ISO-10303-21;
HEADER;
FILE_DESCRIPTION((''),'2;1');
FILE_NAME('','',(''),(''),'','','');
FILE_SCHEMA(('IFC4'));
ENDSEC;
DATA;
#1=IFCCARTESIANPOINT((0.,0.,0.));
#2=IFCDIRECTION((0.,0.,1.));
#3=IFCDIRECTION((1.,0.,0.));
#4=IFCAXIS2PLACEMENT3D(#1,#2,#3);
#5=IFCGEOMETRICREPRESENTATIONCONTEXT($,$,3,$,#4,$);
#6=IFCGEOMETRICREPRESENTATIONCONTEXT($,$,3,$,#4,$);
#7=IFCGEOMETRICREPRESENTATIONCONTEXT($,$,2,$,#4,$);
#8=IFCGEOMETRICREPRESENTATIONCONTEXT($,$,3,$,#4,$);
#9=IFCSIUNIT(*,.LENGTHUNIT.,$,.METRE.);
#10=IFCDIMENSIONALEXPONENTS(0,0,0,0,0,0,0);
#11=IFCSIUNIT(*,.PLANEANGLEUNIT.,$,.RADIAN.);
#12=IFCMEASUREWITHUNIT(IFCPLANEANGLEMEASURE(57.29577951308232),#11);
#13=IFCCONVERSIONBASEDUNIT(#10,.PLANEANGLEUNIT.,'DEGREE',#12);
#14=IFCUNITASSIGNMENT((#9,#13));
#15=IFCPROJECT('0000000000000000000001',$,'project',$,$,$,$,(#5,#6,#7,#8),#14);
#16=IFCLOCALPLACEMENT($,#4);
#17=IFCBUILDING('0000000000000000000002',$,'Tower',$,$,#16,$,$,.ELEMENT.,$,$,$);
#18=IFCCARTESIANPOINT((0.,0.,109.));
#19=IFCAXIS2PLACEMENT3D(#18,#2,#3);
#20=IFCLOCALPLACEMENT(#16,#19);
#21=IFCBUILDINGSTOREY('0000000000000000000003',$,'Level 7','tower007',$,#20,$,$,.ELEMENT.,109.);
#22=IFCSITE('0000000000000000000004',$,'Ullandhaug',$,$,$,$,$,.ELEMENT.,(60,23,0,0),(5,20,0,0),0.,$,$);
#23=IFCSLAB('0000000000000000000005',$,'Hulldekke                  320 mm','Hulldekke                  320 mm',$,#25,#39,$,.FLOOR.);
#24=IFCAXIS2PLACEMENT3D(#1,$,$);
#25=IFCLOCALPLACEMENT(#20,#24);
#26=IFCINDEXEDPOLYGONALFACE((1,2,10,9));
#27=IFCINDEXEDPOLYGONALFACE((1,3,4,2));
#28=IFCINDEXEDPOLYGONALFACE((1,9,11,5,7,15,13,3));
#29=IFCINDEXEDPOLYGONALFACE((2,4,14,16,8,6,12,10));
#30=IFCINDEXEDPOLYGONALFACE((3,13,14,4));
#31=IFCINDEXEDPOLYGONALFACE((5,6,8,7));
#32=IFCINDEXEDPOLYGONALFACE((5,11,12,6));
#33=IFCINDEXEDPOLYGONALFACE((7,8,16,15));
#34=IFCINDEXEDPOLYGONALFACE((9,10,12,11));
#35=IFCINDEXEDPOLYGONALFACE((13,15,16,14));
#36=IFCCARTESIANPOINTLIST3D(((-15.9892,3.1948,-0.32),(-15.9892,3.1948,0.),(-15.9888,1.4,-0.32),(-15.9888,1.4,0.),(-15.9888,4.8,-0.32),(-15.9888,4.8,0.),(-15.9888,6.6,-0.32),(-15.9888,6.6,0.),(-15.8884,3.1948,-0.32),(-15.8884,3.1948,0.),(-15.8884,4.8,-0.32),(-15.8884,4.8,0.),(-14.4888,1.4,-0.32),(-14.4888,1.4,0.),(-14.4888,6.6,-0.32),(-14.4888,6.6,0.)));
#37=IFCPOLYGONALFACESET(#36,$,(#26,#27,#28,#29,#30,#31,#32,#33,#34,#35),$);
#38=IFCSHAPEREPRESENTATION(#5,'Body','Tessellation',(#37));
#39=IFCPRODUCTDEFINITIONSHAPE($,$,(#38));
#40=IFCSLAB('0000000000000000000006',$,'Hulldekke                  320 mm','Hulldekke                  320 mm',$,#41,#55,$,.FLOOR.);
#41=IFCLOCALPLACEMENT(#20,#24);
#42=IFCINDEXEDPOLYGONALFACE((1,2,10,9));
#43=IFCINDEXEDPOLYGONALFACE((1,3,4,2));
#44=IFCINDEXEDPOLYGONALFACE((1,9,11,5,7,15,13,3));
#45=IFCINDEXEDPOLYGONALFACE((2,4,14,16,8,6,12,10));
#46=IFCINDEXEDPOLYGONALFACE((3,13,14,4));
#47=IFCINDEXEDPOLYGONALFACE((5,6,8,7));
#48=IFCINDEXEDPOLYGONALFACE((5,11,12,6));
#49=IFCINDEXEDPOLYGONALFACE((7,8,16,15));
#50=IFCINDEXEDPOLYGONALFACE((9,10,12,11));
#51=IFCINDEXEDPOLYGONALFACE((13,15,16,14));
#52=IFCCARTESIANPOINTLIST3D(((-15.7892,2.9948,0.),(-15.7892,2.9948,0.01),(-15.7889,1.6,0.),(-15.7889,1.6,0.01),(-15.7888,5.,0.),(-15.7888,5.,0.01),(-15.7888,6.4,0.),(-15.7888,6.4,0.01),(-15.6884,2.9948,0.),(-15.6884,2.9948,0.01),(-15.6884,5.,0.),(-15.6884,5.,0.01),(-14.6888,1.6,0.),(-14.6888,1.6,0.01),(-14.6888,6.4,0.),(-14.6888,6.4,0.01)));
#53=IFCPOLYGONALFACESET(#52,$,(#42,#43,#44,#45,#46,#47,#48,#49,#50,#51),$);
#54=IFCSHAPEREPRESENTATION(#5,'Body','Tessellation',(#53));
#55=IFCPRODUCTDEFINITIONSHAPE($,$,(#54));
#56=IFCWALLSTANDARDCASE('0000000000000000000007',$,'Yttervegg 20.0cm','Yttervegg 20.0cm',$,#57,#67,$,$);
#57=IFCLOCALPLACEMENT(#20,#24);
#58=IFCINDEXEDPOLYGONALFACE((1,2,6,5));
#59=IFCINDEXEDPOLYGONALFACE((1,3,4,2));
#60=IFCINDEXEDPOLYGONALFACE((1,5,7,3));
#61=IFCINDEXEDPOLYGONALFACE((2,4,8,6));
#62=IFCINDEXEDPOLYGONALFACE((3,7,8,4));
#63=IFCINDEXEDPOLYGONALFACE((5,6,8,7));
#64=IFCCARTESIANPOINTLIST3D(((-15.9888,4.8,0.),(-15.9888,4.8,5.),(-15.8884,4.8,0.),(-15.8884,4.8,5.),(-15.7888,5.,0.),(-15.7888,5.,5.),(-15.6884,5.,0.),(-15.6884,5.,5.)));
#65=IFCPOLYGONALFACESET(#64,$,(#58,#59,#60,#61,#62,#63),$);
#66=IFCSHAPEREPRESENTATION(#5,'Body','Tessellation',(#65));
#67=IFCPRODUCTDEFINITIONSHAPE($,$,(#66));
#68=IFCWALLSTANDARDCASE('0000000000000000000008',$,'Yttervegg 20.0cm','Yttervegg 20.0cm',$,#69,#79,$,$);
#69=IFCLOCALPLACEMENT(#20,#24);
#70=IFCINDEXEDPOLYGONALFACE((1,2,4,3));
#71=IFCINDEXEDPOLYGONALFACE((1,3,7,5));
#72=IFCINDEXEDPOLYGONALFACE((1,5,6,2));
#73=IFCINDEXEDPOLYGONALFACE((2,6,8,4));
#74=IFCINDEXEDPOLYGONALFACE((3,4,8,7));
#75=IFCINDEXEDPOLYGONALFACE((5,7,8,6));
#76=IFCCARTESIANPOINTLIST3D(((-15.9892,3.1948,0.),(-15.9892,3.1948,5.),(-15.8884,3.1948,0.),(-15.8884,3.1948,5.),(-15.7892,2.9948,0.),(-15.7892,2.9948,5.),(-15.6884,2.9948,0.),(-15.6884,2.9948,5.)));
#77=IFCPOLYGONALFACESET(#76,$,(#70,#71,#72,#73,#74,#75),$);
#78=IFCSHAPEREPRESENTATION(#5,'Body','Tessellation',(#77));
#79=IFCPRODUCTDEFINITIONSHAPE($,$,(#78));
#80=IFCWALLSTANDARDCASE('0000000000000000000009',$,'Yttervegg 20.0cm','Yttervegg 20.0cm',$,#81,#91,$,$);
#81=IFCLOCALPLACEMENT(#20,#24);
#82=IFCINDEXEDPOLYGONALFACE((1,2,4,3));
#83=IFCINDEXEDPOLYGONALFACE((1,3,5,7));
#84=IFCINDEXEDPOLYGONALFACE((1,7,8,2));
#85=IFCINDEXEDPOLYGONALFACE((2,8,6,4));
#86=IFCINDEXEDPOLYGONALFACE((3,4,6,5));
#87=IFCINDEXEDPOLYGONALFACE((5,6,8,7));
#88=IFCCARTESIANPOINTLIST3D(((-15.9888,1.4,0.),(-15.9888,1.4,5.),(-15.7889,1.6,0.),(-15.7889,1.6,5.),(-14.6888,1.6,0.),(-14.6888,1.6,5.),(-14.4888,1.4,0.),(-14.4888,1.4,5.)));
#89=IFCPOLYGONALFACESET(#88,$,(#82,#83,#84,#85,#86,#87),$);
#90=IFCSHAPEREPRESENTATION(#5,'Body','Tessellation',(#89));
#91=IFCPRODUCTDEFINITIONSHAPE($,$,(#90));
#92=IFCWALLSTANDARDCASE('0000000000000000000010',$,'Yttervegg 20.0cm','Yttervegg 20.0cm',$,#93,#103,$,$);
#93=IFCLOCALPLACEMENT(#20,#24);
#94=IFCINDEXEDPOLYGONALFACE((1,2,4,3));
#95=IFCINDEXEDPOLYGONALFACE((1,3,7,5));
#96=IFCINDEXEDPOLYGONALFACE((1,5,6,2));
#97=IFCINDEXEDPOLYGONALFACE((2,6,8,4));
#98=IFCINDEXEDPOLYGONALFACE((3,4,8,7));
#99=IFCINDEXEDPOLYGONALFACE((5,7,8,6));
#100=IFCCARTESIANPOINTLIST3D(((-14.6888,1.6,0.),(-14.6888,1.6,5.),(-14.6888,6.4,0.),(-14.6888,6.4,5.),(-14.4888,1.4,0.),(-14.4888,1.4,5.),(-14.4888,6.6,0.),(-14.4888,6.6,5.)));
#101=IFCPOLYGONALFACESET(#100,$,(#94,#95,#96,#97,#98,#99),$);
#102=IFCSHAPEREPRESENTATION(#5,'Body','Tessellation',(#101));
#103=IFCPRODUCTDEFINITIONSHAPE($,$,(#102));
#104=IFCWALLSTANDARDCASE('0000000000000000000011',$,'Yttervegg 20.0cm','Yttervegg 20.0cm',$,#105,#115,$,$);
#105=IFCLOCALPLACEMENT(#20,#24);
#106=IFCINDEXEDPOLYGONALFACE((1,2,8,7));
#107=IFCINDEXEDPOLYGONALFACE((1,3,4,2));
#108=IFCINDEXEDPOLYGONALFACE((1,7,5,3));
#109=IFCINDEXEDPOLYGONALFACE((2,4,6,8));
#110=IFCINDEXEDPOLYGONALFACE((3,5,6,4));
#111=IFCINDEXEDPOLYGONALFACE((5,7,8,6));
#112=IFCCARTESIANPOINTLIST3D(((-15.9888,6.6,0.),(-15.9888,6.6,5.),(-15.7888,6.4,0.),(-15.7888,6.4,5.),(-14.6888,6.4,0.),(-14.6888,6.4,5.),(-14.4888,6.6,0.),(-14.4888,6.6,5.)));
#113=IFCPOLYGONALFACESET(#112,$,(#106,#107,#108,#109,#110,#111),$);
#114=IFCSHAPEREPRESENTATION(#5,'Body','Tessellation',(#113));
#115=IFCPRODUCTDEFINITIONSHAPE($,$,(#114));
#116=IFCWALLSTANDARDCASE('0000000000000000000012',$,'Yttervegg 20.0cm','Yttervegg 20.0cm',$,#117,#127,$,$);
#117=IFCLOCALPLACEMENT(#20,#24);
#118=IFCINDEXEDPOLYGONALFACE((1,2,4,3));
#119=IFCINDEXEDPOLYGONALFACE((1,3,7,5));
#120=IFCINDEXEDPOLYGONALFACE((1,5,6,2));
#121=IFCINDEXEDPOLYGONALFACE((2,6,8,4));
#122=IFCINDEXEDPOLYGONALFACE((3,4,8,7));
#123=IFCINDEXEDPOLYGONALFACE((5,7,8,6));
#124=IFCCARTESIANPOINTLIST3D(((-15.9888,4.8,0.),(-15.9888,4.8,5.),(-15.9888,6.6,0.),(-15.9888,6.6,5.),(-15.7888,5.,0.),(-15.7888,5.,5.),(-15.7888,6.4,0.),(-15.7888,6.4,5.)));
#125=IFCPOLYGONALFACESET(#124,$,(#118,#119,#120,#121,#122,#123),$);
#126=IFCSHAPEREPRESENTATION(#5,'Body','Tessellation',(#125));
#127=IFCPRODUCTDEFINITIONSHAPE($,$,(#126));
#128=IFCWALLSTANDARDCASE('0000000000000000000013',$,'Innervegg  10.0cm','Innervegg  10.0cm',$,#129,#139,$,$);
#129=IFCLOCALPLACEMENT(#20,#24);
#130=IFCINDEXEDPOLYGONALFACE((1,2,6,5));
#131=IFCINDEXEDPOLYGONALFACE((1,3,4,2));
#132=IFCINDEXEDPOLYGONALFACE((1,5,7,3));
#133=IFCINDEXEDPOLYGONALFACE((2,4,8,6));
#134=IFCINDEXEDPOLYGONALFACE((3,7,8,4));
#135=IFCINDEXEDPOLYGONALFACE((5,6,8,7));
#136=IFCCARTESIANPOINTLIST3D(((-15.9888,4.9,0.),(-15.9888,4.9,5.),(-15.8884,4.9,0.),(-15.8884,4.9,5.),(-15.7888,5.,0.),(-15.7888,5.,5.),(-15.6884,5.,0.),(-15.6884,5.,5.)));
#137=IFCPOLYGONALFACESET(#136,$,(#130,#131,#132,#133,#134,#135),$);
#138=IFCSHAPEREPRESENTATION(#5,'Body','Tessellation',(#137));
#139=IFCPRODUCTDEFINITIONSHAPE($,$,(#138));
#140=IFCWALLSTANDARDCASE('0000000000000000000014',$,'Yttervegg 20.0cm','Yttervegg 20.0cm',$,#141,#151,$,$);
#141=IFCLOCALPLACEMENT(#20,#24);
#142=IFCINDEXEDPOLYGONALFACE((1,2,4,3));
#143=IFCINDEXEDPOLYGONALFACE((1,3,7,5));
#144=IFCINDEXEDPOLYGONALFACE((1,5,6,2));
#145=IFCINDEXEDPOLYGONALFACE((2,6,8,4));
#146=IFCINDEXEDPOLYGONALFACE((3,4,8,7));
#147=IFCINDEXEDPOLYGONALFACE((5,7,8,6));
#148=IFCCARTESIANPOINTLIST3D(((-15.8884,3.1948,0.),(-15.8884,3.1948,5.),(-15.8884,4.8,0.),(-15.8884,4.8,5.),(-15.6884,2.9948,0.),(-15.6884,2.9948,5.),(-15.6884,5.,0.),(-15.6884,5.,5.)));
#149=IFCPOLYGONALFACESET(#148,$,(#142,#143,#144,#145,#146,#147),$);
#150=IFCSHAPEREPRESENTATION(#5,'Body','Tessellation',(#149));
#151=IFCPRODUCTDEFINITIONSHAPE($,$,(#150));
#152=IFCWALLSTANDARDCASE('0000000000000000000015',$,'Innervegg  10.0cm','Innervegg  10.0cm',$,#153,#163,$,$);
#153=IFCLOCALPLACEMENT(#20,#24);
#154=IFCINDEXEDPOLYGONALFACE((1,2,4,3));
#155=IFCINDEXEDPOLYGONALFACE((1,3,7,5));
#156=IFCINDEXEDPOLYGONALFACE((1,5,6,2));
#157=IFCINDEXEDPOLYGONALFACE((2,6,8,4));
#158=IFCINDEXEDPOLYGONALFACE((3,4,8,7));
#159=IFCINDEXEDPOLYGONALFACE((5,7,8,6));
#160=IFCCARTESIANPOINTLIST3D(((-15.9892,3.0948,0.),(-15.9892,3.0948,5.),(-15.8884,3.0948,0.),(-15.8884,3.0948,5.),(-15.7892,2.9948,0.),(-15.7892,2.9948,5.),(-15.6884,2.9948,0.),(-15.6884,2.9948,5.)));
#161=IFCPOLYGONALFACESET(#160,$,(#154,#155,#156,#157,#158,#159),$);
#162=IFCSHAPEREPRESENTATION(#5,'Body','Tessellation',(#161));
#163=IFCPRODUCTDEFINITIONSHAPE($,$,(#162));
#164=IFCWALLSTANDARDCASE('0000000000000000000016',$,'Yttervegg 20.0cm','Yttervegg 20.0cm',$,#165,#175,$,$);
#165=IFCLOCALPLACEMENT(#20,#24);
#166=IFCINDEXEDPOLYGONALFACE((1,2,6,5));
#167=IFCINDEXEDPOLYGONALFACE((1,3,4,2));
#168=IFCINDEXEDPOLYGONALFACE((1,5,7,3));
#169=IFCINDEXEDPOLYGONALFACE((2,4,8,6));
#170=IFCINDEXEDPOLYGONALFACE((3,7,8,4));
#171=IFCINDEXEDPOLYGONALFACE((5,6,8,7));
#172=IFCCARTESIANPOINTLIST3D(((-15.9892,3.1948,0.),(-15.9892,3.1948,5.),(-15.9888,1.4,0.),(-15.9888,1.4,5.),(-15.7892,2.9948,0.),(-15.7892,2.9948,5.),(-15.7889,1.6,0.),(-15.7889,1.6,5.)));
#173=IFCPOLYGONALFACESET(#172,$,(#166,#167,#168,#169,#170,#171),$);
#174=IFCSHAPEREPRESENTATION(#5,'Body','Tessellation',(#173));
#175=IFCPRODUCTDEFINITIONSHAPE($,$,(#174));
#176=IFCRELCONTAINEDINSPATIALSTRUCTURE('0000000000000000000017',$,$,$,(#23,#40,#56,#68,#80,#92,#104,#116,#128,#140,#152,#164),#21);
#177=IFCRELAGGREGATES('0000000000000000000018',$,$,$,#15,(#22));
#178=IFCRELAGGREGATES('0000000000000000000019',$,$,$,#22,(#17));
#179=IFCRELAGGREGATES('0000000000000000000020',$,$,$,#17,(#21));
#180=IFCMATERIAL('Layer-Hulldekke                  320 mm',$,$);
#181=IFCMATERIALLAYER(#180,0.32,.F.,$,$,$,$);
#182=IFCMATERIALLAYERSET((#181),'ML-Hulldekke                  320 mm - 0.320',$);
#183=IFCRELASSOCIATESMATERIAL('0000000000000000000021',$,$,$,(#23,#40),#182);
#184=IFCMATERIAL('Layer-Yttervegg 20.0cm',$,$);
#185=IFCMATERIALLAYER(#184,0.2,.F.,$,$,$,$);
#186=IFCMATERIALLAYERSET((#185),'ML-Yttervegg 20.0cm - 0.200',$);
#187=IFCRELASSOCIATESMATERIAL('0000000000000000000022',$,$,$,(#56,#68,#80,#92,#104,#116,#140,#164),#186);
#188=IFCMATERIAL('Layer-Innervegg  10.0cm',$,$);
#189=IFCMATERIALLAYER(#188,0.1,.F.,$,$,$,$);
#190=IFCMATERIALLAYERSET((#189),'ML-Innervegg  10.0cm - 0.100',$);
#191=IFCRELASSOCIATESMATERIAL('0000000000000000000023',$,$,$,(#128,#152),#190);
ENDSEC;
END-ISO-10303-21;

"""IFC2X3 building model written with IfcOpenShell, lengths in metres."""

from ifc_helpers import new_model, entity, si_unit, converted_unit, frame, origin_with_axes, place, context, project, spatial, polyline, outline, extrude, material, layer, layer_set, layer_usage, element, save


model = new_model("IFC2X3")

# Units and contexts
context_of_model_1 = context(None, 3, world=origin_with_axes())
context_of_model_2 = context(None, 3, world=origin_with_axes())
context_of_model_3 = context(None, 2, world=origin_with_axes())
context_of_model_4 = context(None, 3, world=origin_with_axes())
ifc_project = project(units=[si_unit("LENGTHUNIT", "METRE"), converted_unit("PLANEANGLEUNIT", "DEGREE", entity("IfcPlaneAngleMeasure", 57.29577951308232), si_unit("PLANEANGLEUNIT", "RADIAN"), dimensions=[0, 0, 0, 0, 0, 0, 0])], contexts=[context_of_model_1, context_of_model_2, context_of_model_3, context_of_model_4])

# Site, building, storey
site = spatial("IfcSite", under=ifc_project, Name="Ullandhaug", CompositionType="ELEMENT", RefLatitude=(60, 23, 0, 0), RefLongitude=(5, 20, 0, 0), RefElevation=0.0)
building_placement = place(None, origin_with_axes())
building = spatial("IfcBuilding", under=site, at=building_placement, Name="Tower", CompositionType="ELEMENT")
storey_placement = place(building_placement, frame((0.0, 0.0, 109.0), z_axis=(0.0, 0.0, 1.0), x_axis=(1.0, 0.0, 0.0)))
storey = spatial("IfcBuildingStorey", under=building, at=storey_placement, Name="Level 7", Description="tower007", CompositionType="ELEMENT", Elevation=109.0)

# Slabs
ifc_material_1 = material(Name="Layer-Hulldekke                  320 mm")
ifc_layer_1 = layer(ifc_material_1, 0.32, ventilated=False)
ifc_layer_set_1 = layer_set([ifc_layer_1], Name="ML-Hulldekke                  320 mm - 0.320")
ifc_layer_usage_1 = layer_usage(ifc_layer_set_1, "AXIS2", "POSITIVE", 0.0)
slab_1_placement = place(storey_placement, frame((-15.9888, 1.4, 0.0), z_axis=(0.0, 0.0, 1.0), x_axis=(1.0, 0.0, 0.0)))
element("IfcSlab", 1, at=slab_1_placement, inside=storey, material=ifc_layer_usage_1, Name="Hulldekke                  320 mm", Description="Hulldekke                  320 mm", PredefinedType="FLOOR", context=context_of_model_1, shape_type="SweptSolid", body=[
    extrude(outline(polyline([(0.0, 0.0), (1.5, 0.0), (1.5, 5.2), (0.0, 5.2), (0.0, 3.4), (0.1005, 3.4), (0.1005, 1.7948), (-0.0004, 1.7948), (0.0, 0.0)])), origin_with_axes(), (0.0, 0.0, -1.0), 0.32),
])
slab_2_placement = place(storey_placement, frame((-15.7889, 1.6, 0.0), z_axis=(0.0, 0.0, 1.0), x_axis=(1.0, 0.0, 0.0)))
element("IfcSlab", 2, at=slab_2_placement, inside=storey, material=ifc_layer_usage_1, Name="Hulldekke                  320 mm", Description="Hulldekke                  320 mm", PredefinedType="FLOOR", context=context_of_model_1, shape_type="SweptSolid", body=[
    extrude(outline(polyline([(0.0, 0.0), (1.1, 0.0), (1.1, 4.8), (0.0, 4.8), (0.0, 3.4), (0.1005, 3.4), (0.1005, 1.3948), (-0.0003, 1.3948), (0.0, 0.0)])), origin_with_axes(), (0.0, 0.0, 1.0), 0.01),
])

# Walls
ifc_material_2 = material(Name="Layer-Yttervegg 20.0cm")
ifc_layer_2 = layer(ifc_material_2, 0.2, ventilated=False)
ifc_layer_set_2 = layer_set([ifc_layer_2], Name="ML-Yttervegg 20.0cm - 0.200")
ifc_layer_usage_2 = layer_usage(ifc_layer_set_2, "AXIS2", "POSITIVE", 0.0)
wall_1_placement = place(storey_placement, frame((-15.9888, 4.8, 0.0), z_axis=(0.0, 0.0, 1.0), x_axis=(1.0, 0.0, 0.0)))
element("IfcWallStandardCase", 3, at=wall_1_placement, inside=storey, material=ifc_layer_usage_2, Name="Yttervegg 20.0cm", Description="Yttervegg 20.0cm", context=context_of_model_1, shape_type="SweptSolid", body=[
    extrude(outline(polyline([(0.0, 0.0), (0.1005, 0.0), (0.3005, 0.2), (0.2, 0.2), (0.0, 0.0)])), origin_with_axes(), (0.0, 0.0, 1.0), 5.0),
])
wall_2_placement = place(storey_placement, frame((-15.8884, 3.1948, 0.0), z_axis=(0.0, 0.0, 1.0), x_axis=(-1.0, 0.0, 0.0)))
element("IfcWallStandardCase", 4, at=wall_2_placement, inside=storey, material=ifc_layer_usage_2, Name="Yttervegg 20.0cm", Description="Yttervegg 20.0cm", context=context_of_model_1, shape_type="SweptSolid", body=[
    extrude(outline(polyline([(0.0, 0.0), (0.1009, 0.0), (-0.0992, 0.2), (-0.2, 0.2), (0.0, 0.0)])), frame((0.0, 0.0, 0.0), z_axis=(0.0, 0.0, 1.0), x_axis=(1.0, 0.0, 0.0)), (0.0, 0.0, 1.0), 5.0),
])
wall_3_placement = place(storey_placement, frame((-15.9888, 1.4, 0.0), z_axis=(0.0, 0.0, 1.0), x_axis=(1.0, 0.0, 0.0)))
element("IfcWallStandardCase", 5, at=wall_3_placement, inside=storey, material=ifc_layer_usage_2, Name="Yttervegg 20.0cm", Description="Yttervegg 20.0cm", context=context_of_model_1, shape_type="SweptSolid", body=[
    extrude(outline(polyline([(0.0, 0.0), (1.5, 0.0), (1.3, 0.2), (0.2, 0.2), (0.0, 0.0)])), origin_with_axes(), (0.0, 0.0, 1.0), 5.0),
])
wall_4_placement = place(storey_placement, frame((-14.4888, 1.4, 0.0), z_axis=(0.0, 0.0, 1.0), x_axis=(0.0, 1.0, 0.0)))
element("IfcWallStandardCase", 6, at=wall_4_placement, inside=storey, material=ifc_layer_usage_2, Name="Yttervegg 20.0cm", Description="Yttervegg 20.0cm", context=context_of_model_1, shape_type="SweptSolid", body=[
    extrude(outline(polyline([(0.0, 0.0), (5.2, 0.0), (5.0, 0.2), (0.2, 0.2), (0.0, 0.0)])), frame((0.0, 0.0, 0.0), z_axis=(0.0, 0.0, 1.0), x_axis=(1.0, 0.0, 0.0)), (0.0, 0.0, 1.0), 5.0),
])
wall_5_placement = place(storey_placement, frame((-14.4888, 6.6, 0.0), z_axis=(0.0, 0.0, 1.0), x_axis=(-1.0, 0.0, 0.0)))
element("IfcWallStandardCase", 7, at=wall_5_placement, inside=storey, material=ifc_layer_usage_2, Name="Yttervegg 20.0cm", Description="Yttervegg 20.0cm", context=context_of_model_1, shape_type="SweptSolid", body=[
    extrude(outline(polyline([(0.0, 0.0), (1.5, 0.0), (1.3, 0.2), (0.2, 0.2), (0.0, 0.0)])), frame((0.0, 0.0, 0.0), z_axis=(0.0, 0.0, 1.0), x_axis=(1.0, 0.0, 0.0)), (0.0, 0.0, 1.0), 5.0),
])
wall_6_placement = place(storey_placement, frame((-15.9888, 6.6, 0.0), z_axis=(0.0, 0.0, 1.0), x_axis=(0.0, -1.0, 0.0)))
element("IfcWallStandardCase", 8, at=wall_6_placement, inside=storey, material=ifc_layer_usage_2, Name="Yttervegg 20.0cm", Description="Yttervegg 20.0cm", context=context_of_model_1, shape_type="SweptSolid", body=[
    extrude(outline(polyline([(0.0, 0.0), (1.8, 0.0), (1.6, 0.2), (0.2, 0.2), (0.0, 0.0)])), frame((0.0, 0.0, 0.0), z_axis=(0.0, 0.0, 1.0), x_axis=(1.0, 0.0, 0.0)), (0.0, 0.0, 1.0), 5.0),
])
ifc_material_3 = material(Name="Layer-Innervegg  10.0cm")
ifc_layer_3 = layer(ifc_material_3, 0.1, ventilated=False)
ifc_layer_set_3 = layer_set([ifc_layer_3], Name="ML-Innervegg  10.0cm - 0.100")
ifc_layer_usage_3 = layer_usage(ifc_layer_set_3, "AXIS2", "POSITIVE", 0.0)
wall_7_placement = place(storey_placement, frame((-15.9888, 4.9, 0.0), z_axis=(0.0, 0.0, 1.0), x_axis=(1.0, 0.0, 0.0)))
element("IfcWallStandardCase", 9, at=wall_7_placement, inside=storey, material=ifc_layer_usage_3, Name="Innervegg  10.0cm", Description="Innervegg  10.0cm", context=context_of_model_1, shape_type="SweptSolid", body=[
    extrude(outline(polyline([(0.0, 0.0), (0.1005, 0.0), (0.3005, 0.1), (0.2, 0.1), (0.0, 0.0)])), origin_with_axes(), (0.0, 0.0, 1.0), 5.0),
])
wall_8_placement = place(storey_placement, frame((-15.8884, 4.8, 0.0), z_axis=(0.0, 0.0, 1.0), x_axis=(0.0, -1.0, 0.0)))
element("IfcWallStandardCase", 10, at=wall_8_placement, inside=storey, material=ifc_layer_usage_2, Name="Yttervegg 20.0cm", Description="Yttervegg 20.0cm", context=context_of_model_1, shape_type="SweptSolid", body=[
    extrude(outline(polyline([(0.0, 0.0), (1.6052, 0.0), (1.8052, 0.2), (-0.2, 0.2), (0.0, 0.0)])), frame((0.0, 0.0, 0.0), z_axis=(0.0, 0.0, 1.0), x_axis=(1.0, 0.0, 0.0)), (0.0, 0.0, 1.0), 5.0),
])
wall_9_placement = place(storey_placement, frame((-15.8884, 3.0948, 0.0), z_axis=(0.0, 0.0, 1.0), x_axis=(-1.0, 0.0, 0.0)))
element("IfcWallStandardCase", 11, at=wall_9_placement, inside=storey, material=ifc_layer_usage_3, Name="Innervegg  10.0cm", Description="Innervegg  10.0cm", context=context_of_model_1, shape_type="SweptSolid", body=[
    extrude(outline(polyline([(0.0, 0.0), (0.1009, 0.0), (-0.0992, 0.1), (-0.2, 0.1), (0.0, 0.0)])), frame((0.0, 0.0, 0.0), z_axis=(0.0, 0.0, 1.0), x_axis=(1.0, 0.0, 0.0)), (0.0, 0.0, 1.0), 5.0),
])
wall_10_placement = place(storey_placement, frame((-15.9892, 3.1948, 0.0), z_axis=(0.0, 0.0, 1.0), x_axis=(0.000225, -1.0, 0.0)))
element("IfcWallStandardCase", 12, at=wall_10_placement, inside=storey, material=ifc_layer_usage_2, Name="Yttervegg 20.0cm", Description="Yttervegg 20.0cm", context=context_of_model_1, shape_type="SweptSolid", body=[
    extrude(outline(polyline([(0.0, 0.0), (1.7948, 0.0), (1.5948, 0.2), (0.2, 0.2), (0.0, 0.0)])), frame((0.0, 0.0, 0.0), z_axis=(0.0, 0.0, 1.0), x_axis=(1.0, 0.0, 0.0)), (0.0, 0.0, 1.0), 5.0),
])

save(model, "model.ifc")
